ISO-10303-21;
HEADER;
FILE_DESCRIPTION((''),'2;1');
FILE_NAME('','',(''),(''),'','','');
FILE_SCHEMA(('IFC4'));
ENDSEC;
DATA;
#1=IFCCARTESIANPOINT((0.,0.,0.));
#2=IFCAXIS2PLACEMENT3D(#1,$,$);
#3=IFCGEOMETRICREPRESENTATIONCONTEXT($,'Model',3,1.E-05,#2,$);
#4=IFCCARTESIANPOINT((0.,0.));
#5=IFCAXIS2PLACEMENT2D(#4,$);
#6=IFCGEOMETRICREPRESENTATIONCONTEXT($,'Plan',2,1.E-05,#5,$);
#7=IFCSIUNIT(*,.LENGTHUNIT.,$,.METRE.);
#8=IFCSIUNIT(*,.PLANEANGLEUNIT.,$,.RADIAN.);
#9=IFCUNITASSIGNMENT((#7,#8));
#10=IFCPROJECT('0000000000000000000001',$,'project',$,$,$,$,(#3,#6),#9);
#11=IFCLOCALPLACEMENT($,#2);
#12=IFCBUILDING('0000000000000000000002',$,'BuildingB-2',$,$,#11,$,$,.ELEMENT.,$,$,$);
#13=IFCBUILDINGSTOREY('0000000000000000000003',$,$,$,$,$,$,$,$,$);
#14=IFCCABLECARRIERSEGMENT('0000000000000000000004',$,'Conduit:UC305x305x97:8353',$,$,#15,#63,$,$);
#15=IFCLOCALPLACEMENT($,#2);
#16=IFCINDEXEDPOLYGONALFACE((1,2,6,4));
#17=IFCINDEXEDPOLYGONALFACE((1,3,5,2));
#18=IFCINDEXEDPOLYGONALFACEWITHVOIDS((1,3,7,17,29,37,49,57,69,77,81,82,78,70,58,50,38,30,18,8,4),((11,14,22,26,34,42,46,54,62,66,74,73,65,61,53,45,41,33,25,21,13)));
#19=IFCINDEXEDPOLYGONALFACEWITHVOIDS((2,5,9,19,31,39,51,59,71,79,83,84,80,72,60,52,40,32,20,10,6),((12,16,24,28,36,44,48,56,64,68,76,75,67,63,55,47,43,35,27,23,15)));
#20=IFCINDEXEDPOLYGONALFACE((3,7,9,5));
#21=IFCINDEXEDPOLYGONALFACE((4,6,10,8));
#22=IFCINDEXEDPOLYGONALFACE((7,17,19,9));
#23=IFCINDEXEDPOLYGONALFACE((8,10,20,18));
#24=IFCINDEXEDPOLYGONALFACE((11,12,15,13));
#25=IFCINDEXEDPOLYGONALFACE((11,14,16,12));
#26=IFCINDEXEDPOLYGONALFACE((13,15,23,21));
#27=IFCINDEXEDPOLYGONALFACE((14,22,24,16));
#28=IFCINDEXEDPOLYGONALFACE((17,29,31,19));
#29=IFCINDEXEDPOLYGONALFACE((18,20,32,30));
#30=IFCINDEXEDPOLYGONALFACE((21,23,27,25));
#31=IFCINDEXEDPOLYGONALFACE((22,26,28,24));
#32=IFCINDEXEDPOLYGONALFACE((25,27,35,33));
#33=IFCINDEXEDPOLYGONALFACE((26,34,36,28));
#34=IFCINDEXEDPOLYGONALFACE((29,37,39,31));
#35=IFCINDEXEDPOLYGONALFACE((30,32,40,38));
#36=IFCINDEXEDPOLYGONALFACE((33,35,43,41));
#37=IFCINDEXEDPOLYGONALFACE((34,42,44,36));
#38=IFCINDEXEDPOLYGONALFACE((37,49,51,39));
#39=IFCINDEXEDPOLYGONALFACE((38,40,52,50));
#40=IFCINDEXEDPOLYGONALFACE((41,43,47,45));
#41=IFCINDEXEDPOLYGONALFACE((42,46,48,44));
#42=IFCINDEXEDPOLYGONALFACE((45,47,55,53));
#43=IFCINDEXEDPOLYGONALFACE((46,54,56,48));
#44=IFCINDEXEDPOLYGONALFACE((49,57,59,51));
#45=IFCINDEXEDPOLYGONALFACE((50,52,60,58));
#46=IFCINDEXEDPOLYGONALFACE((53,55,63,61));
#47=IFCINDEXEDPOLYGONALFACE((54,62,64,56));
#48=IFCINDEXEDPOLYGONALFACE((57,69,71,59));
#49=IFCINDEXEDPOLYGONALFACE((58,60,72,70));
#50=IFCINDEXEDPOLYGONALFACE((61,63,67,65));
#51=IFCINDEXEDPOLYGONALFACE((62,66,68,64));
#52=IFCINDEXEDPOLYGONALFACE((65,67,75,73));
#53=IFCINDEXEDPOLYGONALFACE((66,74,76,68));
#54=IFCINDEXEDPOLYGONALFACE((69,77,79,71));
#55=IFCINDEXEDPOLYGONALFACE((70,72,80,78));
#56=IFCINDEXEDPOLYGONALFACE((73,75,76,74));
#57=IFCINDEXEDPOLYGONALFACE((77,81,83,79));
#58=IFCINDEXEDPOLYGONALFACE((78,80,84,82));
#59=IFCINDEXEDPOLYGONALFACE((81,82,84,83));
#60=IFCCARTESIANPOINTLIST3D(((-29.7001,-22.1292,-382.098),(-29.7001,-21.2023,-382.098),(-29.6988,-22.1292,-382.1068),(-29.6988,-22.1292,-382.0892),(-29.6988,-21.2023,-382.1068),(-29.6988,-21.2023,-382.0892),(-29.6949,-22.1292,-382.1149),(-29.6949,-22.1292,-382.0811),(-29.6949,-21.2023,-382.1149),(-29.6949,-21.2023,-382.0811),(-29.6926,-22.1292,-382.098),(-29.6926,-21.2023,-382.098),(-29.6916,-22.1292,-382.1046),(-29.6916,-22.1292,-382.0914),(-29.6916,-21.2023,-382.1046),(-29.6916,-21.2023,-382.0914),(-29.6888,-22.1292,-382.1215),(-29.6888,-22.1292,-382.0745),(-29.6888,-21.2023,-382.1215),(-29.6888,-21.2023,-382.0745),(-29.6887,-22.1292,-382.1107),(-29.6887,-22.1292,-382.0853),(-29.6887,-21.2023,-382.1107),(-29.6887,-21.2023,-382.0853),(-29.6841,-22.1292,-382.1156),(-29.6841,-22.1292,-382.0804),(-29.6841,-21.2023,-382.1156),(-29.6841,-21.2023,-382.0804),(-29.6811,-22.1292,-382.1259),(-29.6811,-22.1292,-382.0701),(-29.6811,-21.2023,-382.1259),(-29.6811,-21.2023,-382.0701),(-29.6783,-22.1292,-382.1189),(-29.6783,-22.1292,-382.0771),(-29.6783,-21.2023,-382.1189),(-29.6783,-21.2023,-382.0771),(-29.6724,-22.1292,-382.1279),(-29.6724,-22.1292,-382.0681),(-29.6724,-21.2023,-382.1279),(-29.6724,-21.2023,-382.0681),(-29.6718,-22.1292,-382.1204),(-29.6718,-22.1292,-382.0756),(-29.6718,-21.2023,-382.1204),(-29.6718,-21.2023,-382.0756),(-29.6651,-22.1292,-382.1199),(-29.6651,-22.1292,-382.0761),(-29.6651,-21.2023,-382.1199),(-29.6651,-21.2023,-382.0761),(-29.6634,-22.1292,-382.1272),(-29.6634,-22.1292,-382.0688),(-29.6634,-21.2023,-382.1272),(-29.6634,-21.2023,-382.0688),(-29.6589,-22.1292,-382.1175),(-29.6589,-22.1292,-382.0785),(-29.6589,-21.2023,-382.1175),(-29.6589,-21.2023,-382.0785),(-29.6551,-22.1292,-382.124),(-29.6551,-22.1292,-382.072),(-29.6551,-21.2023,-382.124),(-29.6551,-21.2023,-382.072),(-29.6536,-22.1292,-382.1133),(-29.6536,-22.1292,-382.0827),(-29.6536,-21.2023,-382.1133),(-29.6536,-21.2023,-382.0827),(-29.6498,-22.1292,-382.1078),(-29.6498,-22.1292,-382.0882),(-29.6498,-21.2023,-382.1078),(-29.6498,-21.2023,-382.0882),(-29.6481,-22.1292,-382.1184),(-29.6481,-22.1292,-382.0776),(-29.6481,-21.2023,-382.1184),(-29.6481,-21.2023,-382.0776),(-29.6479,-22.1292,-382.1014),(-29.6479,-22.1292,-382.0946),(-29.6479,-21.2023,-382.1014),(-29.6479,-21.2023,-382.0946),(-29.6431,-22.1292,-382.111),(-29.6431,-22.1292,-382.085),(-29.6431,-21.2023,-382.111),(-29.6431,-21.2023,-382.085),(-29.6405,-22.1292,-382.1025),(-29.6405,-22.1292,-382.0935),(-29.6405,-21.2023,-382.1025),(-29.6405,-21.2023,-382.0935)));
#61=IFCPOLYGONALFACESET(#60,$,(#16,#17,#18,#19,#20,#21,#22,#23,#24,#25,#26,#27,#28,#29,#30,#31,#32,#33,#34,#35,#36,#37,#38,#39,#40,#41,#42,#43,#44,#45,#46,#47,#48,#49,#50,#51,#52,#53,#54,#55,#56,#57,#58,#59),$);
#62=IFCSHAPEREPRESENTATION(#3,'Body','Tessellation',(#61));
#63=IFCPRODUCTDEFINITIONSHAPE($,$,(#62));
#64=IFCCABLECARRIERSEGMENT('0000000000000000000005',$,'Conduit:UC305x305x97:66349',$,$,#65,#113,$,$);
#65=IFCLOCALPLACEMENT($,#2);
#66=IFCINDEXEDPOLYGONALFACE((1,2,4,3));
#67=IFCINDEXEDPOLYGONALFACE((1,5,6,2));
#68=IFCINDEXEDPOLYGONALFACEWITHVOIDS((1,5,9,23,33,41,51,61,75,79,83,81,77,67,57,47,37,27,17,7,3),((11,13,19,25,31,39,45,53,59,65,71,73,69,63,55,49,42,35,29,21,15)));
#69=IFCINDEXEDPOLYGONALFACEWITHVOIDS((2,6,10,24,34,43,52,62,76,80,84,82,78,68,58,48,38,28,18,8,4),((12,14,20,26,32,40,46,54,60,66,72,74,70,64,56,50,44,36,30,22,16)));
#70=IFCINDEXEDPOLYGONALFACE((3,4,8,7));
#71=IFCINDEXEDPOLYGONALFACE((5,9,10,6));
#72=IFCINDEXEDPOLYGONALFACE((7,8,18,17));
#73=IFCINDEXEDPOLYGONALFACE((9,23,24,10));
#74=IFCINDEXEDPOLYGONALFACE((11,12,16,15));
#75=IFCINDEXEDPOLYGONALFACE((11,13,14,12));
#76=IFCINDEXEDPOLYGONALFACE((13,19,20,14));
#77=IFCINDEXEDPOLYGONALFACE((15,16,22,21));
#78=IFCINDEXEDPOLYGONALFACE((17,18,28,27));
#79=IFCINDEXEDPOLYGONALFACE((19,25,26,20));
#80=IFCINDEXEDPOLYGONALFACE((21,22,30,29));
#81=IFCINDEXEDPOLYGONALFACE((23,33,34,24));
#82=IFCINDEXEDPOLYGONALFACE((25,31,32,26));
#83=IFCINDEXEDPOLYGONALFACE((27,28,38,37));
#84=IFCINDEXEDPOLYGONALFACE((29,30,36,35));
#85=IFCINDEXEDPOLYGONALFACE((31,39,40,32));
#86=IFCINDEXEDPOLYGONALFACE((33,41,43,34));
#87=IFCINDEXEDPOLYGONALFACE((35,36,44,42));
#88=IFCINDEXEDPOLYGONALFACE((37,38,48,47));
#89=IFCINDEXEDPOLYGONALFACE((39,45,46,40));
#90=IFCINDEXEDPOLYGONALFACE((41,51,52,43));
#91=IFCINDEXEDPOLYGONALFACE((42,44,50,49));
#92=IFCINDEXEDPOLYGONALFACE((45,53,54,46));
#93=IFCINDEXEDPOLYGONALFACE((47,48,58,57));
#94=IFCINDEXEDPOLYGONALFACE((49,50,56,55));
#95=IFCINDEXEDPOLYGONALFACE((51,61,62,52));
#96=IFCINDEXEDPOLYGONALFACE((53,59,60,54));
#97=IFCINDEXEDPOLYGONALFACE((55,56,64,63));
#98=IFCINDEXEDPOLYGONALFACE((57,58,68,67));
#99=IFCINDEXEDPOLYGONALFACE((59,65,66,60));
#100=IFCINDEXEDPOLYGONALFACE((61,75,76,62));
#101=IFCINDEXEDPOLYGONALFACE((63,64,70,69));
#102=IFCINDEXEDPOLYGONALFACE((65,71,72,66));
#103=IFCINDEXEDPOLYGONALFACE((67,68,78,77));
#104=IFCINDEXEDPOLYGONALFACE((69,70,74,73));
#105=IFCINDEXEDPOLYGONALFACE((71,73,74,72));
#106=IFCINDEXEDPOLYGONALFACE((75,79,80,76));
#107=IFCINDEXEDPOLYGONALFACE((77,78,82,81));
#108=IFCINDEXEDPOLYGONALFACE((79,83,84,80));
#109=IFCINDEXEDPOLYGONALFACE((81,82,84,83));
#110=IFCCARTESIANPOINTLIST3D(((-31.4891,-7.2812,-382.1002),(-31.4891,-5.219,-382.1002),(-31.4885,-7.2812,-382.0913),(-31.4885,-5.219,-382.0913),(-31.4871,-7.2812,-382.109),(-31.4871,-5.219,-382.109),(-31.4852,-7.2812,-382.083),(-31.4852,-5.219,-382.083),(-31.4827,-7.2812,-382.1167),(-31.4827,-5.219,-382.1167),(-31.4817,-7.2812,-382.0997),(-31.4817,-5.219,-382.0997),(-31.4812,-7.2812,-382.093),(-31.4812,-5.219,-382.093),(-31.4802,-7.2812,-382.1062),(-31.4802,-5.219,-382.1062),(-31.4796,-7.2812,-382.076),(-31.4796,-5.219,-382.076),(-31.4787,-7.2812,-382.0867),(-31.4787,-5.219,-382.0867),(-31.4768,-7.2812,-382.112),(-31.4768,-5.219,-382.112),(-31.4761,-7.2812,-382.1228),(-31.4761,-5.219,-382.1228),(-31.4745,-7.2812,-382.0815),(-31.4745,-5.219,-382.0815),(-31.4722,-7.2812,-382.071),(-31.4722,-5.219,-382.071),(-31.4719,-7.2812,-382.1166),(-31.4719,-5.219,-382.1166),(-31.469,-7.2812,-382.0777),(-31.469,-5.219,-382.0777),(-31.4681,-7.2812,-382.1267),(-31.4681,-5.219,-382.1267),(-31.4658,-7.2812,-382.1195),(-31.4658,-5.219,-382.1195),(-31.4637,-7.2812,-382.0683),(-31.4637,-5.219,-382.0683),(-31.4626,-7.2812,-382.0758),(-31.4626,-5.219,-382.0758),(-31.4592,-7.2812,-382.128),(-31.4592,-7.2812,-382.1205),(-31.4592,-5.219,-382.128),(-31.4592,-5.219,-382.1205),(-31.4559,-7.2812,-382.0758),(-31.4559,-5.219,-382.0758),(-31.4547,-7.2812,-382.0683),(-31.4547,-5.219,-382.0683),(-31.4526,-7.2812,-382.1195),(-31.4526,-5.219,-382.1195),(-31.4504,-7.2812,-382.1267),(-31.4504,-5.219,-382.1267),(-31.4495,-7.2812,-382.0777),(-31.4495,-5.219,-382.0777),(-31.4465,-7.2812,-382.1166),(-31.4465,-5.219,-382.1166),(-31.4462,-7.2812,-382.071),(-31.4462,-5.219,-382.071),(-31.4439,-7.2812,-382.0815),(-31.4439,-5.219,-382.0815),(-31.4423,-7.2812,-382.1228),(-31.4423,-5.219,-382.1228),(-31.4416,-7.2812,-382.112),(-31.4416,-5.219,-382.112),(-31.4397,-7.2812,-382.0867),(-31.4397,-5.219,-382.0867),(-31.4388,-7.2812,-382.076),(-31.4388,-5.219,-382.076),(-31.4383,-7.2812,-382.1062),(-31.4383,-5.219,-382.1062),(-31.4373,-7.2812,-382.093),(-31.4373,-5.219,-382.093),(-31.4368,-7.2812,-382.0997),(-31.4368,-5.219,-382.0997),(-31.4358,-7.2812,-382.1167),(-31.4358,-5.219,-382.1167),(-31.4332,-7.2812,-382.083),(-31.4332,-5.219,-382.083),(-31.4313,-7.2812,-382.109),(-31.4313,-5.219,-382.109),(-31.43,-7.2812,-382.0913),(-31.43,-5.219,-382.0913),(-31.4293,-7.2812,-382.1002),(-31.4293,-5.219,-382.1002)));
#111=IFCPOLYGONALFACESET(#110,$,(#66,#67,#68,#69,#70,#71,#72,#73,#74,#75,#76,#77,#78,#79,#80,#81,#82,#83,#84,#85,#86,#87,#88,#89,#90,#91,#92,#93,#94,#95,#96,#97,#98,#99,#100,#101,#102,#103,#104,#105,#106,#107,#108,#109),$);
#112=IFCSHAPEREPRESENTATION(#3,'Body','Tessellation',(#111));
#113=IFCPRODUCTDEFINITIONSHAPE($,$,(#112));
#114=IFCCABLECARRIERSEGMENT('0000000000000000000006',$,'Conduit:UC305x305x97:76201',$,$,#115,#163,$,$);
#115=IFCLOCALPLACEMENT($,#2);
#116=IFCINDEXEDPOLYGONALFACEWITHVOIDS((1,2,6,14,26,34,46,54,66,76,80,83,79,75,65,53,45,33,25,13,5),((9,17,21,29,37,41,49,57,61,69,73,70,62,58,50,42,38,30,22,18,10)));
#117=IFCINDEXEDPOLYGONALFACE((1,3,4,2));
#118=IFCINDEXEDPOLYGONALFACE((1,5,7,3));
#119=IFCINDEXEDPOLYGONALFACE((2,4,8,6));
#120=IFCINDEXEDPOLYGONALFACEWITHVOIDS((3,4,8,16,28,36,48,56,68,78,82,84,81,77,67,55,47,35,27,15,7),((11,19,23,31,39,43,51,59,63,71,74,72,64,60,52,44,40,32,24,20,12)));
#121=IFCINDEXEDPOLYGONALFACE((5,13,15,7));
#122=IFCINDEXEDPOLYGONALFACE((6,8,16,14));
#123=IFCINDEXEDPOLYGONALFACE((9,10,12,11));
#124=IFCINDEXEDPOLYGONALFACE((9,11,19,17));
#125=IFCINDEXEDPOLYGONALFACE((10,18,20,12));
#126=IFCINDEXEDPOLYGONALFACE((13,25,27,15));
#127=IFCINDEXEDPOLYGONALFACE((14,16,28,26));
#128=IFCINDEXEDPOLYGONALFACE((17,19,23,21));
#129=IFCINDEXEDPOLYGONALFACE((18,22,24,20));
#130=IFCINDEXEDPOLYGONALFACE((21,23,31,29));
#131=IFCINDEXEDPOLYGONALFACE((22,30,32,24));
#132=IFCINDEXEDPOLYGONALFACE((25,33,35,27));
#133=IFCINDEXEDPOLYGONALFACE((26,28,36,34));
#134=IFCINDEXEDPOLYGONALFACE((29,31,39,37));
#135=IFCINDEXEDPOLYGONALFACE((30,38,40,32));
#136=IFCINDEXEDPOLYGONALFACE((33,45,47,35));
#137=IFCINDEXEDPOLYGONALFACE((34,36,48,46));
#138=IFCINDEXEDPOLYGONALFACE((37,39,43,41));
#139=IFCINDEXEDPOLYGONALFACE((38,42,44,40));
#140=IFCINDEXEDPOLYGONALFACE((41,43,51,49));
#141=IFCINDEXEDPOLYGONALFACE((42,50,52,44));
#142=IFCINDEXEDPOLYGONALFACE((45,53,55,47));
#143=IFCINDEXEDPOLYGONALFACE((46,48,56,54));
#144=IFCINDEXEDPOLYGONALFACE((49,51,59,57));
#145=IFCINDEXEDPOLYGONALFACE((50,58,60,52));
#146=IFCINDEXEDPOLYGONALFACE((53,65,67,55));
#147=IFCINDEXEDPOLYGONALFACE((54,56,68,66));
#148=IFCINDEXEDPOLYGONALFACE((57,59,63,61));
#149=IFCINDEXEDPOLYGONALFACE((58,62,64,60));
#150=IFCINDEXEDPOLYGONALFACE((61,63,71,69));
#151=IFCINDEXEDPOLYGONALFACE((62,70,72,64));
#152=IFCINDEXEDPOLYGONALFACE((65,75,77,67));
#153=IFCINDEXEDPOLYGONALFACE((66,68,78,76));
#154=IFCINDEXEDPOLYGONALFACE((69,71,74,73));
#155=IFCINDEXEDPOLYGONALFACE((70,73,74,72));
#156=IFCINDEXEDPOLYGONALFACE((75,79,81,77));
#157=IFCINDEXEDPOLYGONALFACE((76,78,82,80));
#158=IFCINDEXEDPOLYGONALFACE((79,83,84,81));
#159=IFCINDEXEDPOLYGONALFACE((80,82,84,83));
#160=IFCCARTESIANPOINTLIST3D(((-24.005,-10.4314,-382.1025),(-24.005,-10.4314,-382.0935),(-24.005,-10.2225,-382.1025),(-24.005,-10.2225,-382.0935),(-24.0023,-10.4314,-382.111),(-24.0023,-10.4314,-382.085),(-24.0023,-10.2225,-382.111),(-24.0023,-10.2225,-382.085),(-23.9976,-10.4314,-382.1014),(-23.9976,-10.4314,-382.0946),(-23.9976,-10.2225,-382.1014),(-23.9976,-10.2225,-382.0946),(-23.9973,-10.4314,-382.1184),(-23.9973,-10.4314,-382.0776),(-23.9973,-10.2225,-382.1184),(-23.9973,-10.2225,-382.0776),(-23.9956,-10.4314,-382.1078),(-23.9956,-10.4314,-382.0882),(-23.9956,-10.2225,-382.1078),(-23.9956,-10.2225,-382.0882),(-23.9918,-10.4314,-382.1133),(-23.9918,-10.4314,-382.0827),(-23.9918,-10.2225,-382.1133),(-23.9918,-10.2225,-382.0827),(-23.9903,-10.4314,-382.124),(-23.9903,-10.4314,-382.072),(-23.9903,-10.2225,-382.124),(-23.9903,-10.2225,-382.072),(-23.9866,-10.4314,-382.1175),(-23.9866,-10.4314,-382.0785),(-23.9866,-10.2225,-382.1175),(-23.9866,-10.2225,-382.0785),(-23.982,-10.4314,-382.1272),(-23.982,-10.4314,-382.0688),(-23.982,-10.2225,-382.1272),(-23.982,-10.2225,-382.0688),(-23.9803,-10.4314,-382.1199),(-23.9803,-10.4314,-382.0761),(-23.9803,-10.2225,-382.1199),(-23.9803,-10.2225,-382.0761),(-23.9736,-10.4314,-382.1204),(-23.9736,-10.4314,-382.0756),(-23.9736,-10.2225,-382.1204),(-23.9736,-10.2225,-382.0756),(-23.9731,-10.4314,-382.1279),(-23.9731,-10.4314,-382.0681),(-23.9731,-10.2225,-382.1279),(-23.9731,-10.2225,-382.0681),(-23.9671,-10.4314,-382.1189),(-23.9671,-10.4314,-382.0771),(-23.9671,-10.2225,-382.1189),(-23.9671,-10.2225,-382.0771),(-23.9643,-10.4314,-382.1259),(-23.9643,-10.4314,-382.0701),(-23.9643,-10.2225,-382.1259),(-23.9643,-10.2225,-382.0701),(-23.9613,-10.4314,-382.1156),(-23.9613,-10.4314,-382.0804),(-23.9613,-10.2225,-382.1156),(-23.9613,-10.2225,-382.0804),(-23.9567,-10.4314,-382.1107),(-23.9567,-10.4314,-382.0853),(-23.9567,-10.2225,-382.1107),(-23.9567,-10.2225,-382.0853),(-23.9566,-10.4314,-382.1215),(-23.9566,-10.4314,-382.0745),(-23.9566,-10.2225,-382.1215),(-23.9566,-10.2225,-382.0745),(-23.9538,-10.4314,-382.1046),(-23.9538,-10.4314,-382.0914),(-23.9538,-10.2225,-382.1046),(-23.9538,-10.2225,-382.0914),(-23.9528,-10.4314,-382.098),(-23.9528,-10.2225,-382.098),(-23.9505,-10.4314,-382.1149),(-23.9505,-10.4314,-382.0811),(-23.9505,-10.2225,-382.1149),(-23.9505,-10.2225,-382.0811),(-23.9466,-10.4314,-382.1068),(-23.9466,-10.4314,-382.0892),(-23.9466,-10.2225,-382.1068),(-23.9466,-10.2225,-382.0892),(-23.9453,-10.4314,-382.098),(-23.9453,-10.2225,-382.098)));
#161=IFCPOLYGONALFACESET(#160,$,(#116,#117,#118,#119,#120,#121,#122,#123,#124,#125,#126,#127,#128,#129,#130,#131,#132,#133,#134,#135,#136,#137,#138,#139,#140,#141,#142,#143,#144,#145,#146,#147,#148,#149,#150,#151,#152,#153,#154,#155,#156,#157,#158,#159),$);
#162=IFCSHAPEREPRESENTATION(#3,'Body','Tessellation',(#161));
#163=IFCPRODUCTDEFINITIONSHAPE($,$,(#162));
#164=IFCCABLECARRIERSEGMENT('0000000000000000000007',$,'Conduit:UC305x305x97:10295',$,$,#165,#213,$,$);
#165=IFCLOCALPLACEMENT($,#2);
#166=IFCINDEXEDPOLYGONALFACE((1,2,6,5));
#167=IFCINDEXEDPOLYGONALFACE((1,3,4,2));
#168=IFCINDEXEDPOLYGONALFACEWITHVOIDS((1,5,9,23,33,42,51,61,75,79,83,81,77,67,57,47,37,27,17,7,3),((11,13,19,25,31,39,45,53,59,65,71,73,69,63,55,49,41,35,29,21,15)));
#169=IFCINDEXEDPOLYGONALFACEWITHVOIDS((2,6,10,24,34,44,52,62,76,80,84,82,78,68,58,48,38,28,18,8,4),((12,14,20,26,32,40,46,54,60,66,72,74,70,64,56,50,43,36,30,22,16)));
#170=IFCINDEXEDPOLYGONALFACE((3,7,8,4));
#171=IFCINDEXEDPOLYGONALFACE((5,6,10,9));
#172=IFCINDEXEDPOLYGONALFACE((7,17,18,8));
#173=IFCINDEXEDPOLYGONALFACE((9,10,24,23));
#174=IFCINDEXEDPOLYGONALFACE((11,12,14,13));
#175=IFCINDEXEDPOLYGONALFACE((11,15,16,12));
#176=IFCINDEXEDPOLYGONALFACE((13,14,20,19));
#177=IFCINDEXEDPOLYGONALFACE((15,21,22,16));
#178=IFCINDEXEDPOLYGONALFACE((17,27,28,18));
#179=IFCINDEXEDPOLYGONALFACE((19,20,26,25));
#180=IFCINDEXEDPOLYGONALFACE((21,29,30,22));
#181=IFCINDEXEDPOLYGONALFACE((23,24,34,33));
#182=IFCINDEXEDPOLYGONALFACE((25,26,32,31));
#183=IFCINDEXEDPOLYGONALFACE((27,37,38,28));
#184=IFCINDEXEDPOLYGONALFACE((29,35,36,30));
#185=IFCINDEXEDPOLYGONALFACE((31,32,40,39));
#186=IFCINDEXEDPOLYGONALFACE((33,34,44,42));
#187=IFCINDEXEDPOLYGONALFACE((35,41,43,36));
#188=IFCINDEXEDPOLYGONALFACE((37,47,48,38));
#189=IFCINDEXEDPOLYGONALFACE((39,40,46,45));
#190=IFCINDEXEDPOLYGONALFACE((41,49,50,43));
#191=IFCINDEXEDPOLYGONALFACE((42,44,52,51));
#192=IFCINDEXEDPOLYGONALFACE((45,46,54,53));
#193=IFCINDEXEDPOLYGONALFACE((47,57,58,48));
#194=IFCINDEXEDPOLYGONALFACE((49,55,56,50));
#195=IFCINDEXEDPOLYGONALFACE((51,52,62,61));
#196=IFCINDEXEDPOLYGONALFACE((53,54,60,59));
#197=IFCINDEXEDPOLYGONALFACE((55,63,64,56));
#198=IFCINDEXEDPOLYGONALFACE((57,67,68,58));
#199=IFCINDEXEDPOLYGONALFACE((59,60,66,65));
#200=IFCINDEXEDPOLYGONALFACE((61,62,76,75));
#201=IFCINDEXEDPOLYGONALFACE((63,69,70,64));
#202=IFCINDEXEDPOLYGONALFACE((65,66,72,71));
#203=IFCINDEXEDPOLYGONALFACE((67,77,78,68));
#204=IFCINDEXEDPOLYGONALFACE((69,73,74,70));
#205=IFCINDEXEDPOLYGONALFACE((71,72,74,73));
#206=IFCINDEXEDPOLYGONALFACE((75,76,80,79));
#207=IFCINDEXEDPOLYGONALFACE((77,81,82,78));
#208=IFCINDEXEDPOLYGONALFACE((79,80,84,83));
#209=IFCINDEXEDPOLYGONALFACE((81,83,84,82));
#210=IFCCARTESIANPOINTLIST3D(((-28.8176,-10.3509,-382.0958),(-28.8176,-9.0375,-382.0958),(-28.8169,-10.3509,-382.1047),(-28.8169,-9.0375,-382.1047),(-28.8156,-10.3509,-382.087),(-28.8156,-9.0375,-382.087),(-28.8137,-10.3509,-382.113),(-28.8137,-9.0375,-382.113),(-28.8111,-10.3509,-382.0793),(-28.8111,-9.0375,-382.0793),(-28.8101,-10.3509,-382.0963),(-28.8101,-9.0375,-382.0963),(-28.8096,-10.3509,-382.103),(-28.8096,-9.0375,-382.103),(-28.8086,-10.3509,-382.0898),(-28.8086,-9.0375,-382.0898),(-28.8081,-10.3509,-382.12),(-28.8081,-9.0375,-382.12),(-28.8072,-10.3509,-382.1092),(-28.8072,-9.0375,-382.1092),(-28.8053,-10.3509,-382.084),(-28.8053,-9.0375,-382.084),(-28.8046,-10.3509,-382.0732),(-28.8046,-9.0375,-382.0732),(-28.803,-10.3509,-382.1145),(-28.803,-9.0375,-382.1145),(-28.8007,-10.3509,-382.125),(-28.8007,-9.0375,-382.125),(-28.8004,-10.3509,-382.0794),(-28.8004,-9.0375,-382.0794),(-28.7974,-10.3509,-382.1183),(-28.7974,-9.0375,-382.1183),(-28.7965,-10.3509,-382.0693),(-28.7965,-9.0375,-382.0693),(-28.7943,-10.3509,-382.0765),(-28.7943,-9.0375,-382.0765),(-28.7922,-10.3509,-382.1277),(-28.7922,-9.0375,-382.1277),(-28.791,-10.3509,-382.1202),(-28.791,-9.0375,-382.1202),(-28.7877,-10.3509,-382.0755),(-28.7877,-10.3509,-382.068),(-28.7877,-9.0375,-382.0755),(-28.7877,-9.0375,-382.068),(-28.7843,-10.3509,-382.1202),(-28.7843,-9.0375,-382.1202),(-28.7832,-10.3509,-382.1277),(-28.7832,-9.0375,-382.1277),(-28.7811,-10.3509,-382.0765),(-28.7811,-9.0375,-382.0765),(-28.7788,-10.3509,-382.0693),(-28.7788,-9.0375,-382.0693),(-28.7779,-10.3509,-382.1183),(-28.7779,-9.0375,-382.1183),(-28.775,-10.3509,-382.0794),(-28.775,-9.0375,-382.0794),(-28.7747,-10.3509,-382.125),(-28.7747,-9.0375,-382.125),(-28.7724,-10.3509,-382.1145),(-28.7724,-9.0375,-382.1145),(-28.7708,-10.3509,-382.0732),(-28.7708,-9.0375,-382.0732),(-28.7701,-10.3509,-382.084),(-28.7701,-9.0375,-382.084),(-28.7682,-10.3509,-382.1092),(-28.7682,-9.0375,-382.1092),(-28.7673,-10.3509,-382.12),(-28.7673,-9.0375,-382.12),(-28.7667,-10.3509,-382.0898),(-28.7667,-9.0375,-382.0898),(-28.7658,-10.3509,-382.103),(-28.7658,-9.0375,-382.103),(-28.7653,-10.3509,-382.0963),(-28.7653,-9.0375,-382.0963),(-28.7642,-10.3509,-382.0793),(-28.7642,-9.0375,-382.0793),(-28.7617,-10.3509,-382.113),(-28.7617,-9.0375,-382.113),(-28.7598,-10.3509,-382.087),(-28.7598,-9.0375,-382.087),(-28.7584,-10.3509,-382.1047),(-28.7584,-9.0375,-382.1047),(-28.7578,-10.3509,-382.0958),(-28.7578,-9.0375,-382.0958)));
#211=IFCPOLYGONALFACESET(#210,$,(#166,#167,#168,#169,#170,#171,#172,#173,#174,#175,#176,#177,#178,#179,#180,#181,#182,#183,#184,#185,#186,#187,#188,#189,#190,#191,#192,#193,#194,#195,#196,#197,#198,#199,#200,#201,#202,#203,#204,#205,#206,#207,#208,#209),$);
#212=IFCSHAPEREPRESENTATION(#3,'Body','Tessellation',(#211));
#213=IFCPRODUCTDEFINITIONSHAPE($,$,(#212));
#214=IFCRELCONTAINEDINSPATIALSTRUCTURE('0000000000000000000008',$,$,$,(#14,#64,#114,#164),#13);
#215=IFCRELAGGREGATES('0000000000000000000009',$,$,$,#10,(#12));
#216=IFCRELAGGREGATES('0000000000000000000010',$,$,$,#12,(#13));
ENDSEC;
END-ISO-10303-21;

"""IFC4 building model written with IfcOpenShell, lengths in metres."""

from ifc_helpers import new_model, entity, si_unit, origin, origin_2d, place, context, project, spatial, element, save


model = new_model("IFC4")

# Units and contexts
model_context = context("Model", 3, precision=1e-05, world=origin())
plan_context = context("Plan", 2, precision=1e-05, world=origin_2d())
ifc_project = project(units=[si_unit("LENGTHUNIT", "METRE"), si_unit("PLANEANGLEUNIT", "RADIAN")], contexts=[model_context, plan_context])

# Building, storey
building_placement = place(None, origin())
building = spatial("IfcBuilding", under=ifc_project, at=building_placement, Name="BuildingB-2", CompositionType="ELEMENT")
storey = spatial("IfcBuildingStorey", under=building)

# Cable carrier segments
element("IfcCableCarrierSegment", 1, inside=storey, Name="Conduit:UC305x305x97:8353", context=model_context, shape_type="AdvancedSweptSolid", body=[
    entity("IfcSweptDiskSolid", entity("IfcCompositeCurve", [entity("IfcCompositeCurveSegment", "CONTINUOUS", False, entity("IfcPolyline", [entity("IfcCartesianPoint", [29.6701, 22.1292, 382.098]), entity("IfcCartesianPoint", [29.6701, 21.2023, 382.098])]))], False), 0.03, 0.0225),
])
element("IfcCableCarrierSegment", 2, inside=storey, Name="Conduit:UC305x305x97:66349", context=model_context, shape_type="AdvancedSweptSolid", body=[
    entity("IfcSweptDiskSolid", entity("IfcCompositeCurve", [entity("IfcCompositeCurveSegment", "CONTINUOUS", False, entity("IfcPolyline", [entity("IfcCartesianPoint", [31.4592, 7.2812, 382.098]), entity("IfcCartesianPoint", [31.4592, 5.219, 382.098])]))], False), 0.03, 0.0225),
])
element("IfcCableCarrierSegment", 3, inside=storey, Name="Conduit:UC305x305x97:76201", context=model_context, shape_type="AdvancedSweptSolid", body=[
    entity("IfcSweptDiskSolid", entity("IfcCompositeCurve", [entity("IfcCompositeCurveSegment", "CONTINUOUS", False, entity("IfcPolyline", [entity("IfcCartesianPoint", [23.9753, 10.2225, 382.098]), entity("IfcCartesianPoint", [23.9753, 10.4314, 382.098])]))], False), 0.03, 0.0225),
])
element("IfcCableCarrierSegment", 4, inside=storey, Name="Conduit:UC305x305x97:10295", context=model_context, shape_type="AdvancedSweptSolid", body=[
    entity("IfcSweptDiskSolid", entity("IfcCompositeCurve", [entity("IfcCompositeCurveSegment", "CONTINUOUS", False, entity("IfcPolyline", [entity("IfcCartesianPoint", [28.7877, 9.0375, 382.098]), entity("IfcCartesianPoint", [28.7877, 10.3509, 382.098])]))], False), 0.03, 0.0225),
])

save(model, "model.ifc")
